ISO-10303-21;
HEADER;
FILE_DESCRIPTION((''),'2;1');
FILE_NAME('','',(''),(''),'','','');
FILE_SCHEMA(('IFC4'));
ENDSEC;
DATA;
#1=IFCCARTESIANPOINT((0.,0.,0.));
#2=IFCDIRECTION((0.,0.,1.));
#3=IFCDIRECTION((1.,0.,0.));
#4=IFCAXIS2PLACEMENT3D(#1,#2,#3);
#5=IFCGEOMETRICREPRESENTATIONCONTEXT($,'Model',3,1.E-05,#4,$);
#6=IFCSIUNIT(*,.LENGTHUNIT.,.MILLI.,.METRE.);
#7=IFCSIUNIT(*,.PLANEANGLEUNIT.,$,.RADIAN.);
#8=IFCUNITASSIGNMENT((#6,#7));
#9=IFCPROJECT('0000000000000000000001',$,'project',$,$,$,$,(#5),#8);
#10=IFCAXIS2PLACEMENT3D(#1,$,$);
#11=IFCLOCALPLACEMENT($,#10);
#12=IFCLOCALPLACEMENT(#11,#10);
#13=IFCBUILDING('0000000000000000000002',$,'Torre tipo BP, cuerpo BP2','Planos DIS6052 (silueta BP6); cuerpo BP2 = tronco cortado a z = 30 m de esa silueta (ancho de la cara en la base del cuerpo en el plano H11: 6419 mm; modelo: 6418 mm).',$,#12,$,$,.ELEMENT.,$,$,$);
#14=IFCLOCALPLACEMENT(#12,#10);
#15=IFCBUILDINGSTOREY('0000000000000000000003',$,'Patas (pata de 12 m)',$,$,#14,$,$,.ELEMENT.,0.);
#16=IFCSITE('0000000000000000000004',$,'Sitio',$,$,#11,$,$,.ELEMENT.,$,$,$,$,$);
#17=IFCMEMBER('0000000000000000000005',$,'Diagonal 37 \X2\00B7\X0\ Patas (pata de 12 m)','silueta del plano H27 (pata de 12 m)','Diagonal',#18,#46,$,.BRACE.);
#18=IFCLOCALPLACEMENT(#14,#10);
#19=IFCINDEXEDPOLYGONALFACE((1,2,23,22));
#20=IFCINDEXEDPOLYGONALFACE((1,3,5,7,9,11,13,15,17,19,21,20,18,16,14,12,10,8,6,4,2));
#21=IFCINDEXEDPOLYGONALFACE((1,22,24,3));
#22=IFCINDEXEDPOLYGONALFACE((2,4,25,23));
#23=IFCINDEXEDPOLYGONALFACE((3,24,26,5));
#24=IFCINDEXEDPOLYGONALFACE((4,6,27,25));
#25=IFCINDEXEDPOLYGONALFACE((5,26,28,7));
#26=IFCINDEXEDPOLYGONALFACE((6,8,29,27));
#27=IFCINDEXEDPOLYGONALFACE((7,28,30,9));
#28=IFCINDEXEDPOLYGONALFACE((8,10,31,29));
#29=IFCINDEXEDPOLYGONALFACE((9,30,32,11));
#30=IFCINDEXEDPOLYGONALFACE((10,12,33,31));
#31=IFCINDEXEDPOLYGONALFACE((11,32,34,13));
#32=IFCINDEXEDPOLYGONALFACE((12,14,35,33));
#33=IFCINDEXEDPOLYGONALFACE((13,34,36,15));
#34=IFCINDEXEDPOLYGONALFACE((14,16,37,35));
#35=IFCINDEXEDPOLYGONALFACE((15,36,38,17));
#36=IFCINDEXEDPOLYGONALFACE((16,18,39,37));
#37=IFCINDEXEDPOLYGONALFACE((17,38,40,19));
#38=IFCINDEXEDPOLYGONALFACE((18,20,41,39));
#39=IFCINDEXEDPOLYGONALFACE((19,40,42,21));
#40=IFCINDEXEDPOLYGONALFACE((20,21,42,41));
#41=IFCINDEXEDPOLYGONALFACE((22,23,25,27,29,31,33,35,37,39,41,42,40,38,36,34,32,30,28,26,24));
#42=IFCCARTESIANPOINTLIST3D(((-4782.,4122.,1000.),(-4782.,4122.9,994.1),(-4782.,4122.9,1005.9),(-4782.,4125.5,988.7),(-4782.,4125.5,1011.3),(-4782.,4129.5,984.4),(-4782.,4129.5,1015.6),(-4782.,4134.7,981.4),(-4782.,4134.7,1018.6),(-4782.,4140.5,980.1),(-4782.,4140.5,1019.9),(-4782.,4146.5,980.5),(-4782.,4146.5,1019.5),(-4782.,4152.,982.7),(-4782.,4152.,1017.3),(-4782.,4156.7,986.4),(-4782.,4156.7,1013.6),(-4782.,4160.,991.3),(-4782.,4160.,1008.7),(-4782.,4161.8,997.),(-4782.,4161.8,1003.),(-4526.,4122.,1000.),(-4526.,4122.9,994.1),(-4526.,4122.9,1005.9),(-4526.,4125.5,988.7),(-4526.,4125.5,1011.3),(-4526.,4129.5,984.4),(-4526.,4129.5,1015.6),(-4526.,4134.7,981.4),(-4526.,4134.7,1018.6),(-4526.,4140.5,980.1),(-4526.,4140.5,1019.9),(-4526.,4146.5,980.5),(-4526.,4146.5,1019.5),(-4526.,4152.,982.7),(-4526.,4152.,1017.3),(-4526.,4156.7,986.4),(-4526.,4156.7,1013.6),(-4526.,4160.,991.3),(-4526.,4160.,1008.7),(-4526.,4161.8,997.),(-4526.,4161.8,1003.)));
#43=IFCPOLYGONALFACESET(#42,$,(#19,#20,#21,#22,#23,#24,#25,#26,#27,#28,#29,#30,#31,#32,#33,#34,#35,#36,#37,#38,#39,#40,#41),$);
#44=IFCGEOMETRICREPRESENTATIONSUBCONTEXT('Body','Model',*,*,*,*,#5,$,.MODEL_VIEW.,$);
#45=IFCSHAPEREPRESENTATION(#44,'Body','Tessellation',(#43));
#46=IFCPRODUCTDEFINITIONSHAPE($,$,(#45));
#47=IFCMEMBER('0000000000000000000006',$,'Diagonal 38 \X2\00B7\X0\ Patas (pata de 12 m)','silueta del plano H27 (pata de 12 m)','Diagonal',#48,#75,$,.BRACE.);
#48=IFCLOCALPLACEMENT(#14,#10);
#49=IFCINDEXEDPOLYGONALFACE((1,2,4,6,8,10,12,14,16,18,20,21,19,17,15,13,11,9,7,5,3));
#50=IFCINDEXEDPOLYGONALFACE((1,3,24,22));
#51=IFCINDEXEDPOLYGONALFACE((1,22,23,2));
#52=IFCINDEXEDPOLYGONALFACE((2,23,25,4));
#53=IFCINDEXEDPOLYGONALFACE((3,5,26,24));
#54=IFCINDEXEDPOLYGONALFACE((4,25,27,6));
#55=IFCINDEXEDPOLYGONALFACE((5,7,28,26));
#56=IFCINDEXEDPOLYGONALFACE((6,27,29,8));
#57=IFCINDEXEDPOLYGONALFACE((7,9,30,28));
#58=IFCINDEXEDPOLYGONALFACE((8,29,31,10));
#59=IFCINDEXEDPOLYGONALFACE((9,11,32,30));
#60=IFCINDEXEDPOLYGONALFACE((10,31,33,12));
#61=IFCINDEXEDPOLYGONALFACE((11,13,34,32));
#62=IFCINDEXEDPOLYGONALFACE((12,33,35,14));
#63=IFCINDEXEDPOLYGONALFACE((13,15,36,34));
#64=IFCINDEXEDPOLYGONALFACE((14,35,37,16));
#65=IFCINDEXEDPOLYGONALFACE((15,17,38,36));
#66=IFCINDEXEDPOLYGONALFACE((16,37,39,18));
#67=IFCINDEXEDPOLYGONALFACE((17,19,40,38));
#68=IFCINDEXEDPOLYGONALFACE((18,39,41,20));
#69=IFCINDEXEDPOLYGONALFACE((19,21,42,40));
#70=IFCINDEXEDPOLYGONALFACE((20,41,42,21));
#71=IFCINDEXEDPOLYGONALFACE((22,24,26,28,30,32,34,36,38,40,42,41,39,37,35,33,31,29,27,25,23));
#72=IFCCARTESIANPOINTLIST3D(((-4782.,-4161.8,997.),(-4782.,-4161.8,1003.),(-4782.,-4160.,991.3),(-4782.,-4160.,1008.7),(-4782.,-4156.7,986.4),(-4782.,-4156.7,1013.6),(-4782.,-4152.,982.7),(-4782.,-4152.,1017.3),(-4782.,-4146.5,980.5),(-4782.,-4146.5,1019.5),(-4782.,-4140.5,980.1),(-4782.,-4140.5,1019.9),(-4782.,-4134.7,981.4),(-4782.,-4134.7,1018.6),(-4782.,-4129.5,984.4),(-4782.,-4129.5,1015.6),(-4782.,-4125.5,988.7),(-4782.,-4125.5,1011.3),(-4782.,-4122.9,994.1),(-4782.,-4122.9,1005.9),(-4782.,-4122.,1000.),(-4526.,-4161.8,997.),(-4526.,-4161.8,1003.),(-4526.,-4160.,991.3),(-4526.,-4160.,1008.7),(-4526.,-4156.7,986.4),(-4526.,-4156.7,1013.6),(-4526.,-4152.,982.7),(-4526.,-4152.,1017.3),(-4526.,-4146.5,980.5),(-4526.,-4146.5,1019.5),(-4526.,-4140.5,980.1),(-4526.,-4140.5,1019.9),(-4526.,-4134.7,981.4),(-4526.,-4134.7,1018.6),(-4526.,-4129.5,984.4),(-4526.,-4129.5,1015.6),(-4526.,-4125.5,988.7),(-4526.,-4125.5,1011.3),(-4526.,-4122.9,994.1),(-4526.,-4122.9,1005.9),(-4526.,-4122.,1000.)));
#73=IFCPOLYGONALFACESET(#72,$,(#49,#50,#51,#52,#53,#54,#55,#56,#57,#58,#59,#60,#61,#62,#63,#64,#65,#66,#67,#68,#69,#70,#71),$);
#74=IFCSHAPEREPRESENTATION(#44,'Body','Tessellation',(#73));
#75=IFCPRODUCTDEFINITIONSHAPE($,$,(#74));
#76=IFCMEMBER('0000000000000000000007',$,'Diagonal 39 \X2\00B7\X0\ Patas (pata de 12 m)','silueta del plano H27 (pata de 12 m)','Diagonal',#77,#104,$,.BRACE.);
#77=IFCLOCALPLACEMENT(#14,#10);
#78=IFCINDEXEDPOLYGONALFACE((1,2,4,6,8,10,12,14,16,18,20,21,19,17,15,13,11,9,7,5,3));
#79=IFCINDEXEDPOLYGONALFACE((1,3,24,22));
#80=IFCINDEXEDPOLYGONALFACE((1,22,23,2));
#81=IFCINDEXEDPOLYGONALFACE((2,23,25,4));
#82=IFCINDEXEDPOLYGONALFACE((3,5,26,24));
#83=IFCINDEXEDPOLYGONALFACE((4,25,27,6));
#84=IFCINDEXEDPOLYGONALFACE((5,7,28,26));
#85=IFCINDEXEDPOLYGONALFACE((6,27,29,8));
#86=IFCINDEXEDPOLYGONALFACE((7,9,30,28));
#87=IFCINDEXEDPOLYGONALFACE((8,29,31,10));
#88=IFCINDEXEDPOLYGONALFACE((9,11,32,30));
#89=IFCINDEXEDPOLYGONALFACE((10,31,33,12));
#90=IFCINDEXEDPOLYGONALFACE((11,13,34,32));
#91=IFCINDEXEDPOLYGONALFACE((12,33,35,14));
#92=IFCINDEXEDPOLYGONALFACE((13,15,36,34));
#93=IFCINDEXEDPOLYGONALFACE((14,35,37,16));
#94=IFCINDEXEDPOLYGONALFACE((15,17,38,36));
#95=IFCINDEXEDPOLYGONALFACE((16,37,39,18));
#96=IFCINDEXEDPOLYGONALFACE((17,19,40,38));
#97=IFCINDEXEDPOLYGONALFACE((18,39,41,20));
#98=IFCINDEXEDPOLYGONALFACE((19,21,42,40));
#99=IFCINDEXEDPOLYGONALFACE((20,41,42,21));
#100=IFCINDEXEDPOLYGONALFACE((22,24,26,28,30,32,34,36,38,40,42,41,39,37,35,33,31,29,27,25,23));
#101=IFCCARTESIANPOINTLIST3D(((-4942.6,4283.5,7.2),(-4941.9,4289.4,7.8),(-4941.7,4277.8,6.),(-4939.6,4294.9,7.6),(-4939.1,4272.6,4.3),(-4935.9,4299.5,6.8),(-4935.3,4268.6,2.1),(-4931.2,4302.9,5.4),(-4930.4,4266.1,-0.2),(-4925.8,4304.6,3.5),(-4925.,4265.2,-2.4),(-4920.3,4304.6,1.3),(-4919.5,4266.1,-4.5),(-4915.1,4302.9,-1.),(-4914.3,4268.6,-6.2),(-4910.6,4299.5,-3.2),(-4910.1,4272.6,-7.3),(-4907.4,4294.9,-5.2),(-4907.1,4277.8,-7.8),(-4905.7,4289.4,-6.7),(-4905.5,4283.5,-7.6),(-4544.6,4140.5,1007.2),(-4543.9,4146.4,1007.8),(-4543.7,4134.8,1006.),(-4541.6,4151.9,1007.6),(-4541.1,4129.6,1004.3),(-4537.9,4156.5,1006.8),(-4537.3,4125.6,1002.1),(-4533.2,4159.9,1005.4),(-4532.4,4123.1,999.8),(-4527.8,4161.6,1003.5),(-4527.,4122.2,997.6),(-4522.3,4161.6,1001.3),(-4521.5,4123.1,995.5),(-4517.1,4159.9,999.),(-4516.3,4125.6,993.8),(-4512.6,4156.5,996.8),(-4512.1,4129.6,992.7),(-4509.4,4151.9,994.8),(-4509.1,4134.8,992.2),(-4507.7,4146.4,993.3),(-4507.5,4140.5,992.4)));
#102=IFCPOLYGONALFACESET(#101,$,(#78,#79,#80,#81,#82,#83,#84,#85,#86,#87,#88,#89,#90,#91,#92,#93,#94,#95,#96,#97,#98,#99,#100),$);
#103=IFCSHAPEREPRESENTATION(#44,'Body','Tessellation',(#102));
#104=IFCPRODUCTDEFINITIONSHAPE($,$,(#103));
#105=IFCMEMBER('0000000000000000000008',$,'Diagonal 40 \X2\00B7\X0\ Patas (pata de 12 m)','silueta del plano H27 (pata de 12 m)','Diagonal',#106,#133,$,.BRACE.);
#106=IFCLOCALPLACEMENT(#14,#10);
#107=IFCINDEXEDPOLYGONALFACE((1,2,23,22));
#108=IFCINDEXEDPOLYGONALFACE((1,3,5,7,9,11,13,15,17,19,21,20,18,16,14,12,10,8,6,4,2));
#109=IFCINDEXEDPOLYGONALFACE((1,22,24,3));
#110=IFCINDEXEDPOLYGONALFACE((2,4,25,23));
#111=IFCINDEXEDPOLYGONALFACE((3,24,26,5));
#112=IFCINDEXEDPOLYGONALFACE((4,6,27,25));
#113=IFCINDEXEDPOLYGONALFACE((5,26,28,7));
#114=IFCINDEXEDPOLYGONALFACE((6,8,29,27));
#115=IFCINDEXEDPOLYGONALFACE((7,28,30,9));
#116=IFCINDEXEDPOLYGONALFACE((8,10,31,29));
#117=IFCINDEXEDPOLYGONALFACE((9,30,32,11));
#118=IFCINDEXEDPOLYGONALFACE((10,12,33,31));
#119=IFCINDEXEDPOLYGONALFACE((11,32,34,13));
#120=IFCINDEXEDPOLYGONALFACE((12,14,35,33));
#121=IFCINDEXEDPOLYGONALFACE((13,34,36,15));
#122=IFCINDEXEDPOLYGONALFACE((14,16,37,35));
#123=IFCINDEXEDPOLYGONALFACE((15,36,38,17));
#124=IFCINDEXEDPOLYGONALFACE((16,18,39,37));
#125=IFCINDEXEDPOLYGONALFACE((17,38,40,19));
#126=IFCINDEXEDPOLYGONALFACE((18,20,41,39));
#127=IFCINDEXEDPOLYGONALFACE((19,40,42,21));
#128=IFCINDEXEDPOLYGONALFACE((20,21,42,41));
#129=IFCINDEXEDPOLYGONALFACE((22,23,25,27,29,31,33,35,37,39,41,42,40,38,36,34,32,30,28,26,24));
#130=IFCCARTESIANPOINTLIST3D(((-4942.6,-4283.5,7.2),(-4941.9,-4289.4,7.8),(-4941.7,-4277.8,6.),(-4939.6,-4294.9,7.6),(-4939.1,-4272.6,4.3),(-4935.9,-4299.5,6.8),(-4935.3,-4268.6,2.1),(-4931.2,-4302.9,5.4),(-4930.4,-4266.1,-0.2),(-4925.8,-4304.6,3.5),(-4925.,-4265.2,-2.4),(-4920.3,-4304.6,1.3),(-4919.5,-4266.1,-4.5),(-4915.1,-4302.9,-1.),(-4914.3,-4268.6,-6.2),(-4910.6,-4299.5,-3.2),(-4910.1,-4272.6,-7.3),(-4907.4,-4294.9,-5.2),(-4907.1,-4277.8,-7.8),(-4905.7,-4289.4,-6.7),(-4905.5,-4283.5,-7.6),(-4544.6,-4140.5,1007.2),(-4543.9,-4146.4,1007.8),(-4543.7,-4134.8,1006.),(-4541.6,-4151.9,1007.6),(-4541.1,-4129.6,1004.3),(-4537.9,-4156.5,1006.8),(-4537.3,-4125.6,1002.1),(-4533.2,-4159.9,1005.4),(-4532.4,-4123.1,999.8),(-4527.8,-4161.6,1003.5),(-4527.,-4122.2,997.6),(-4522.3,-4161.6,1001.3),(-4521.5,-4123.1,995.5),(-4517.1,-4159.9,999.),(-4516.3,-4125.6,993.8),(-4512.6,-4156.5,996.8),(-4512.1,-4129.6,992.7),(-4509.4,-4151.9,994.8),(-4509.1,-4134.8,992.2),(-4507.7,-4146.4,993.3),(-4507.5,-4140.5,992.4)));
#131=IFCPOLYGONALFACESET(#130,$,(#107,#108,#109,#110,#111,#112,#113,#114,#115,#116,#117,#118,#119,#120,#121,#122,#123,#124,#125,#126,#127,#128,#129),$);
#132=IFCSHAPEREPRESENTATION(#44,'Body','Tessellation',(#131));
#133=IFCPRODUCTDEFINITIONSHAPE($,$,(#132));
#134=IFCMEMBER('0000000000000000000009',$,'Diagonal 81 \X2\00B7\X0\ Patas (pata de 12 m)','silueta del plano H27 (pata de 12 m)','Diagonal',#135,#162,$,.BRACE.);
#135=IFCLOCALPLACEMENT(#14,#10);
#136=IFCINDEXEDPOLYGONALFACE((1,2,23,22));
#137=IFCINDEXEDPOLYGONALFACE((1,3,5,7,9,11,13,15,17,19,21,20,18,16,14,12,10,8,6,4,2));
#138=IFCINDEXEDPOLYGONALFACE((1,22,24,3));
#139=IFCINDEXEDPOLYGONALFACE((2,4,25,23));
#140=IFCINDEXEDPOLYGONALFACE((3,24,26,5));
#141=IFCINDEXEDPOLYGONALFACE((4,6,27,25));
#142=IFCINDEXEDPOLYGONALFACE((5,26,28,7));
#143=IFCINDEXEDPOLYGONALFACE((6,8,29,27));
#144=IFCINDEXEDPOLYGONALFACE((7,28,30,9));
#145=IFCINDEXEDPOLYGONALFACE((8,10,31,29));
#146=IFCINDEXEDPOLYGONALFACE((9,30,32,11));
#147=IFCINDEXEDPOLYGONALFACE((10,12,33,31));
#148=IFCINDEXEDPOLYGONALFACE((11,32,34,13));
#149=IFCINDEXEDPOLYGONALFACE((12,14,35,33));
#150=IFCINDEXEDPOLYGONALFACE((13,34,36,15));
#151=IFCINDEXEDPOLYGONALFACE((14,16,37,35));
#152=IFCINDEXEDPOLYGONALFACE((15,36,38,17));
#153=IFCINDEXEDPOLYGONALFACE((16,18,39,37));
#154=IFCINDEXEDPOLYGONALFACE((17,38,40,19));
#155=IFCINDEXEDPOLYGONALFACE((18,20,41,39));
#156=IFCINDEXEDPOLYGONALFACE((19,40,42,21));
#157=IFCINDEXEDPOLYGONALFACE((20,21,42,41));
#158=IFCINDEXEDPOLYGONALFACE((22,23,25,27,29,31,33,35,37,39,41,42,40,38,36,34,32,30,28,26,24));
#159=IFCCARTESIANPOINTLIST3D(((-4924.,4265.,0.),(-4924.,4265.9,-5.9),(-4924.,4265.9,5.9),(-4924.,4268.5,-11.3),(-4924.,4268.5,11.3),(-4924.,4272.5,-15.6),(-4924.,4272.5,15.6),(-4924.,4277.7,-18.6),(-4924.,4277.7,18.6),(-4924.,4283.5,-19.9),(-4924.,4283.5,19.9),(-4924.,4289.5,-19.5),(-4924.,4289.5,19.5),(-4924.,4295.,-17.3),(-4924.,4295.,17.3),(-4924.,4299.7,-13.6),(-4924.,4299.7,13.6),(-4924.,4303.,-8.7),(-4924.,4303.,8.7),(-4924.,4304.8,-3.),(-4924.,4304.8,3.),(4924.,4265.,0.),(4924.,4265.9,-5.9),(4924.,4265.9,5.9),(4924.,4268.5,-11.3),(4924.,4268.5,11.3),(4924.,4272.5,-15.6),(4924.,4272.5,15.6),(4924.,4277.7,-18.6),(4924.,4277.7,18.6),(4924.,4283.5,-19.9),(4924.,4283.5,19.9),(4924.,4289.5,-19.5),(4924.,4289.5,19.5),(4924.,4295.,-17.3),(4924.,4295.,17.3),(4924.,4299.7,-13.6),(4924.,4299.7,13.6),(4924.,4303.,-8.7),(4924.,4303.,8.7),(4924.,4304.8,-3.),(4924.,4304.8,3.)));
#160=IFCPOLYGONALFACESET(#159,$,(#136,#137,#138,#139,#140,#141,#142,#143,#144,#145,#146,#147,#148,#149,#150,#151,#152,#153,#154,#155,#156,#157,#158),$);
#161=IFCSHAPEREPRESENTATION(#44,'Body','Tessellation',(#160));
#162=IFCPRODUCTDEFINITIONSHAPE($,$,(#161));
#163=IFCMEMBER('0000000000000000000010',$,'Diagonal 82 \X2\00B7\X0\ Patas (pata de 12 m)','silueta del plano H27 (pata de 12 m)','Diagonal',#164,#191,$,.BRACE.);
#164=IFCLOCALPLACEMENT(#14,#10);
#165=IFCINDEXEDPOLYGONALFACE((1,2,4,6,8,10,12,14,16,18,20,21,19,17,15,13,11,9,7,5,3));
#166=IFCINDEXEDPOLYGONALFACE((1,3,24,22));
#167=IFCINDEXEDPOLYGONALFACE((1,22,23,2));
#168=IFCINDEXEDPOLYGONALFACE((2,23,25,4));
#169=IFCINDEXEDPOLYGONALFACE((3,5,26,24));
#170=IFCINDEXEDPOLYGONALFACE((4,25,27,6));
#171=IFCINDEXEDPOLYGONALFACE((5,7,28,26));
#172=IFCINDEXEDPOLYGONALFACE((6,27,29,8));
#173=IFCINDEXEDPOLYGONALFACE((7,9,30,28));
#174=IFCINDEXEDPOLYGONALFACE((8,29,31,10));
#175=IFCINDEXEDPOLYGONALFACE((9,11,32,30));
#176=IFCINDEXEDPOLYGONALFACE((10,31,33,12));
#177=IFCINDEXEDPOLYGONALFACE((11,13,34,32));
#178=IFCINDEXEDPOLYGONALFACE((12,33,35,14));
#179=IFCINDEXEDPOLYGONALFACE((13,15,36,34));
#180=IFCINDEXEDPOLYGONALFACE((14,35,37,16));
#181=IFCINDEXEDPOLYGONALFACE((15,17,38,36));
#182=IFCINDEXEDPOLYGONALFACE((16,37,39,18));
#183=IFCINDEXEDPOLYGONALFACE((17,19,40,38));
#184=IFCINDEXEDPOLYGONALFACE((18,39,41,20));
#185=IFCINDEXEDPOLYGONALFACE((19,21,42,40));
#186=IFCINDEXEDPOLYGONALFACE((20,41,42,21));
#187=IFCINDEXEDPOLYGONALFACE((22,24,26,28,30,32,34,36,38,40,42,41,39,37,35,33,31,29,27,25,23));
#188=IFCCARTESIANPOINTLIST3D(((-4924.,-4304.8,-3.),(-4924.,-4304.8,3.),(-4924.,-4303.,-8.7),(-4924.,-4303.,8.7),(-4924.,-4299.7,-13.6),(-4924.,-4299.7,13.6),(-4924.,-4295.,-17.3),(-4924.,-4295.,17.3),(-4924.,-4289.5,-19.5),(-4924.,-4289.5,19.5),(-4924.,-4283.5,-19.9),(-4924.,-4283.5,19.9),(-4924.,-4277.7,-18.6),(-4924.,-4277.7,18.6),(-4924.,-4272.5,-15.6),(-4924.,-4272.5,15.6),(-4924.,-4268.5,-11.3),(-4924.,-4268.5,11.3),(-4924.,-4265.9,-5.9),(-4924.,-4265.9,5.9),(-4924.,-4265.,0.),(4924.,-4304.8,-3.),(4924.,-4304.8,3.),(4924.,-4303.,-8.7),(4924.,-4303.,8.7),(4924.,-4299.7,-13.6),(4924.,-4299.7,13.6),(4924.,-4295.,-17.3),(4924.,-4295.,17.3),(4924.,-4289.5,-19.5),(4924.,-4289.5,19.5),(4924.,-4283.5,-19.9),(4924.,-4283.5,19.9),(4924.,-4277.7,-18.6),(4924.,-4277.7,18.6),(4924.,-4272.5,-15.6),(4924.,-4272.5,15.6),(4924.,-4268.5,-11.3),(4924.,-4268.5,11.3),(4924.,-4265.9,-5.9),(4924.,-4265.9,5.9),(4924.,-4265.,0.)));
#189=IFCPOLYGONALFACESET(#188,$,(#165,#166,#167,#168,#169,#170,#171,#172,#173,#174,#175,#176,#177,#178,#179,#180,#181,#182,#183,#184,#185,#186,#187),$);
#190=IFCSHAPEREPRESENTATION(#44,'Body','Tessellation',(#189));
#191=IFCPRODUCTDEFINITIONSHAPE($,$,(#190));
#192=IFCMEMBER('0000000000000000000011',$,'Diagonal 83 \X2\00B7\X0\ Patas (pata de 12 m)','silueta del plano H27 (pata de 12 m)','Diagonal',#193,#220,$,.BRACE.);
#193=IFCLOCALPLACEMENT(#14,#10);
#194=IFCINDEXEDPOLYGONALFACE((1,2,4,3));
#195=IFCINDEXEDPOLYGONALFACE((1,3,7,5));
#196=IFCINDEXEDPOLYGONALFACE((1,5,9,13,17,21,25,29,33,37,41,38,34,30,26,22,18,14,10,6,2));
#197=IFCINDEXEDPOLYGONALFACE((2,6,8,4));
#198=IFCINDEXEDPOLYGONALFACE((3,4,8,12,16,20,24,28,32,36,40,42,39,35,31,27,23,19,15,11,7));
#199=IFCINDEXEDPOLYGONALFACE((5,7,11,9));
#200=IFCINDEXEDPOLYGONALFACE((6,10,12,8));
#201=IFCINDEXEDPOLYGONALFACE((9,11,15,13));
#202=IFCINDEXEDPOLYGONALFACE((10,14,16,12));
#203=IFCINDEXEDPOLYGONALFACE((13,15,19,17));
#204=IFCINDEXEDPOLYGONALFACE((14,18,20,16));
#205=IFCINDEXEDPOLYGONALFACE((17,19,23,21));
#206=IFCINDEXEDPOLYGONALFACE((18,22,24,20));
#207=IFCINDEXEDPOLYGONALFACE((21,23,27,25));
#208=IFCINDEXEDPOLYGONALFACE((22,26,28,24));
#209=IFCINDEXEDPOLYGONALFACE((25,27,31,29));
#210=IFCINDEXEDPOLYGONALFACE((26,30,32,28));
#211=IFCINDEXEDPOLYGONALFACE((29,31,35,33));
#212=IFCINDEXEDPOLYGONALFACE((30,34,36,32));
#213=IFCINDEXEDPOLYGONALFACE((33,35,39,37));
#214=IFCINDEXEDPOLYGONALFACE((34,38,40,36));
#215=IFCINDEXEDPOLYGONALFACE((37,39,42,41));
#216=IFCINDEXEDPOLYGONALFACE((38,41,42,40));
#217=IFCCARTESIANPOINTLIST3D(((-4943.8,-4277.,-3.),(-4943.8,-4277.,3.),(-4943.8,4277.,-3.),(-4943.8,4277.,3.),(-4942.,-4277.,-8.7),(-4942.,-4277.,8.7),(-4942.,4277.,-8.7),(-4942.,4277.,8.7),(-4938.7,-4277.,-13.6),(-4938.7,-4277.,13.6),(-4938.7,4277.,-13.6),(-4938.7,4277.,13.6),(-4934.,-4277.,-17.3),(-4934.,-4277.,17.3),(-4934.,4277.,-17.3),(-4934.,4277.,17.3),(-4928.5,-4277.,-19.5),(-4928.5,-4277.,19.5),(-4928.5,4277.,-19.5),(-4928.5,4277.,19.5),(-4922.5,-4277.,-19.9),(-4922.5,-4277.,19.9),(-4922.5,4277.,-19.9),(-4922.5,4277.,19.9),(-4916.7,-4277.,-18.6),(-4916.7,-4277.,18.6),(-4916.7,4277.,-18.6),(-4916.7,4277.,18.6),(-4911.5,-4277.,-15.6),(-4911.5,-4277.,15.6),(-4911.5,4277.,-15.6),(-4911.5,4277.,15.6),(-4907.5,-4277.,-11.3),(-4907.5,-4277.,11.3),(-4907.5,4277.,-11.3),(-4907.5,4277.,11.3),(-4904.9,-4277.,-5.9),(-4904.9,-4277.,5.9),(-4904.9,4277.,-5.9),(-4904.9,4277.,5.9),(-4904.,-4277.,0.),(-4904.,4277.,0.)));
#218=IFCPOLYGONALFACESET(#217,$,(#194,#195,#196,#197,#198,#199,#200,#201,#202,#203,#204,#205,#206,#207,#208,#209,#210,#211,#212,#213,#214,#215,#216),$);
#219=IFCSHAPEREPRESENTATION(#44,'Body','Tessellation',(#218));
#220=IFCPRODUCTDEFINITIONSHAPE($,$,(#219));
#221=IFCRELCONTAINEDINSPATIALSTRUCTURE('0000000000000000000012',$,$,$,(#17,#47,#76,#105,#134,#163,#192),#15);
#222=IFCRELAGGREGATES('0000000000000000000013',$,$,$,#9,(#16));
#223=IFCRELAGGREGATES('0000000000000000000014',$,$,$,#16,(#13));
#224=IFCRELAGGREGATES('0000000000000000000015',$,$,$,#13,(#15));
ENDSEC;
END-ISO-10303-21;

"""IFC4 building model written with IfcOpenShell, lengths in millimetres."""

from ifc_helpers import new_model, si_unit, frame, origin, origin_with_axes, place, context, subcontext, project, spatial, circle, extrude, element, save


model = new_model("IFC4")

# Units and contexts
model_context = context("Model", 3, precision=1e-05, world=origin_with_axes())
body_context = subcontext(model_context, "Body", "Model", "MODEL_VIEW")
ifc_project = project(units=[si_unit("LENGTHUNIT", "METRE", prefix="MILLI"), si_unit("PLANEANGLEUNIT", "RADIAN")], contexts=[model_context])

# Site, building, storey
site_placement = place(None, origin())
site = spatial("IfcSite", under=ifc_project, at=site_placement, Name="Sitio", CompositionType="ELEMENT")
building_placement = place(site_placement, origin())
building = spatial("IfcBuilding", under=site, at=building_placement, Name="Torre tipo BP, cuerpo BP2", Description="Planos DIS6052 (silueta BP6); cuerpo BP2 = tronco cortado a z = 30 m de esa silueta (ancho de la cara en la base del cuerpo en el plano H11: 6419 mm; modelo: 6418 mm).", CompositionType="ELEMENT")
storey_placement = place(building_placement, origin())
storey = spatial("IfcBuildingStorey", under=building, at=storey_placement, Name="Patas (pata de 12 m)", CompositionType="ELEMENT", Elevation=0.0)

# Members
for number, where, z_axis, x_axis, name in (
    (1, (-4782.0, 4142.0, 1000.0), (1.0, 0.0, 0.0), (0.0, -1.0, 0.0), "Diagonal 37 · Patas (pata de 12 m)"),
    (2, (-4782.0, -4142.0, 1000.0), (1.0, 0.0, 0.0), (0.0, 1.0, 0.0), "Diagonal 38 · Patas (pata de 12 m)"),
):
    element("IfcMember", number, at=place(storey_placement, frame(where, z_axis=z_axis, x_axis=x_axis)), inside=storey, Name=name, Description="silueta del plano H27 (pata de 12 m)", ObjectType="Diagonal", PredefinedType="BRACE", context=body_context, shape_type="SweptSolid", body=[
        extrude(circle(Radius=20.0), None, (0.0, 0.0, 1.0), 256.0),
    ])
for number, where, z_axis, x_axis, name in (
    (3, (-4924.0, 4285.0, 0.0), (0.366567, -0.131706, 0.921022), (-0.048703, -0.991289, -0.12237), "Diagonal 39 · Patas (pata de 12 m)"),
    (4, (-4924.0, -4285.0, 0.0), (0.366567, 0.131706, 0.921022), (-0.048703, 0.991289, -0.12237), "Diagonal 40 · Patas (pata de 12 m)"),
):
    element("IfcMember", number, at=place(storey_placement, frame(where, z_axis=z_axis, x_axis=x_axis)), inside=storey, Name=name, Description="silueta del plano H27 (pata de 12 m)", ObjectType="Diagonal", PredefinedType="BRACE", context=body_context, shape_type="SweptSolid", body=[
        extrude(circle(Radius=20.0), None, (0.0, 0.0, 1.0), 1085.7),
    ])
for number, where, z_axis, x_axis, name in (
    (5, (-4924.0, 4285.0, 0.0), (1.0, 0.0, 0.0), (0.0, -1.0, 0.0), "Diagonal 81 · Patas (pata de 12 m)"),
    (6, (-4924.0, -4285.0, 0.0), (1.0, 0.0, 0.0), (0.0, 1.0, 0.0), "Diagonal 82 · Patas (pata de 12 m)"),
):
    element("IfcMember", number, at=place(storey_placement, frame(where, z_axis=z_axis, x_axis=x_axis)), inside=storey, Name=name, Description="silueta del plano H27 (pata de 12 m)", ObjectType="Diagonal", PredefinedType="BRACE", context=body_context, shape_type="SweptSolid", body=[
        extrude(circle(Radius=20.0), None, (0.0, 0.0, 1.0), 9848.0),
    ])
member_1_placement = place(storey_placement, frame((-4924.0, 4277.0, 0.0), z_axis=(0.0, -1.0, 0.0), x_axis=(1.0, 0.0, 0.0)))
element("IfcMember", 7, at=member_1_placement, inside=storey, Name="Diagonal 83 · Patas (pata de 12 m)", Description="silueta del plano H27 (pata de 12 m)", ObjectType="Diagonal", PredefinedType="BRACE", context=body_context, shape_type="SweptSolid", body=[
    extrude(circle(Radius=20.0), None, (0.0, 0.0, 1.0), 8554.0),
])

save(model, "model.ifc")
